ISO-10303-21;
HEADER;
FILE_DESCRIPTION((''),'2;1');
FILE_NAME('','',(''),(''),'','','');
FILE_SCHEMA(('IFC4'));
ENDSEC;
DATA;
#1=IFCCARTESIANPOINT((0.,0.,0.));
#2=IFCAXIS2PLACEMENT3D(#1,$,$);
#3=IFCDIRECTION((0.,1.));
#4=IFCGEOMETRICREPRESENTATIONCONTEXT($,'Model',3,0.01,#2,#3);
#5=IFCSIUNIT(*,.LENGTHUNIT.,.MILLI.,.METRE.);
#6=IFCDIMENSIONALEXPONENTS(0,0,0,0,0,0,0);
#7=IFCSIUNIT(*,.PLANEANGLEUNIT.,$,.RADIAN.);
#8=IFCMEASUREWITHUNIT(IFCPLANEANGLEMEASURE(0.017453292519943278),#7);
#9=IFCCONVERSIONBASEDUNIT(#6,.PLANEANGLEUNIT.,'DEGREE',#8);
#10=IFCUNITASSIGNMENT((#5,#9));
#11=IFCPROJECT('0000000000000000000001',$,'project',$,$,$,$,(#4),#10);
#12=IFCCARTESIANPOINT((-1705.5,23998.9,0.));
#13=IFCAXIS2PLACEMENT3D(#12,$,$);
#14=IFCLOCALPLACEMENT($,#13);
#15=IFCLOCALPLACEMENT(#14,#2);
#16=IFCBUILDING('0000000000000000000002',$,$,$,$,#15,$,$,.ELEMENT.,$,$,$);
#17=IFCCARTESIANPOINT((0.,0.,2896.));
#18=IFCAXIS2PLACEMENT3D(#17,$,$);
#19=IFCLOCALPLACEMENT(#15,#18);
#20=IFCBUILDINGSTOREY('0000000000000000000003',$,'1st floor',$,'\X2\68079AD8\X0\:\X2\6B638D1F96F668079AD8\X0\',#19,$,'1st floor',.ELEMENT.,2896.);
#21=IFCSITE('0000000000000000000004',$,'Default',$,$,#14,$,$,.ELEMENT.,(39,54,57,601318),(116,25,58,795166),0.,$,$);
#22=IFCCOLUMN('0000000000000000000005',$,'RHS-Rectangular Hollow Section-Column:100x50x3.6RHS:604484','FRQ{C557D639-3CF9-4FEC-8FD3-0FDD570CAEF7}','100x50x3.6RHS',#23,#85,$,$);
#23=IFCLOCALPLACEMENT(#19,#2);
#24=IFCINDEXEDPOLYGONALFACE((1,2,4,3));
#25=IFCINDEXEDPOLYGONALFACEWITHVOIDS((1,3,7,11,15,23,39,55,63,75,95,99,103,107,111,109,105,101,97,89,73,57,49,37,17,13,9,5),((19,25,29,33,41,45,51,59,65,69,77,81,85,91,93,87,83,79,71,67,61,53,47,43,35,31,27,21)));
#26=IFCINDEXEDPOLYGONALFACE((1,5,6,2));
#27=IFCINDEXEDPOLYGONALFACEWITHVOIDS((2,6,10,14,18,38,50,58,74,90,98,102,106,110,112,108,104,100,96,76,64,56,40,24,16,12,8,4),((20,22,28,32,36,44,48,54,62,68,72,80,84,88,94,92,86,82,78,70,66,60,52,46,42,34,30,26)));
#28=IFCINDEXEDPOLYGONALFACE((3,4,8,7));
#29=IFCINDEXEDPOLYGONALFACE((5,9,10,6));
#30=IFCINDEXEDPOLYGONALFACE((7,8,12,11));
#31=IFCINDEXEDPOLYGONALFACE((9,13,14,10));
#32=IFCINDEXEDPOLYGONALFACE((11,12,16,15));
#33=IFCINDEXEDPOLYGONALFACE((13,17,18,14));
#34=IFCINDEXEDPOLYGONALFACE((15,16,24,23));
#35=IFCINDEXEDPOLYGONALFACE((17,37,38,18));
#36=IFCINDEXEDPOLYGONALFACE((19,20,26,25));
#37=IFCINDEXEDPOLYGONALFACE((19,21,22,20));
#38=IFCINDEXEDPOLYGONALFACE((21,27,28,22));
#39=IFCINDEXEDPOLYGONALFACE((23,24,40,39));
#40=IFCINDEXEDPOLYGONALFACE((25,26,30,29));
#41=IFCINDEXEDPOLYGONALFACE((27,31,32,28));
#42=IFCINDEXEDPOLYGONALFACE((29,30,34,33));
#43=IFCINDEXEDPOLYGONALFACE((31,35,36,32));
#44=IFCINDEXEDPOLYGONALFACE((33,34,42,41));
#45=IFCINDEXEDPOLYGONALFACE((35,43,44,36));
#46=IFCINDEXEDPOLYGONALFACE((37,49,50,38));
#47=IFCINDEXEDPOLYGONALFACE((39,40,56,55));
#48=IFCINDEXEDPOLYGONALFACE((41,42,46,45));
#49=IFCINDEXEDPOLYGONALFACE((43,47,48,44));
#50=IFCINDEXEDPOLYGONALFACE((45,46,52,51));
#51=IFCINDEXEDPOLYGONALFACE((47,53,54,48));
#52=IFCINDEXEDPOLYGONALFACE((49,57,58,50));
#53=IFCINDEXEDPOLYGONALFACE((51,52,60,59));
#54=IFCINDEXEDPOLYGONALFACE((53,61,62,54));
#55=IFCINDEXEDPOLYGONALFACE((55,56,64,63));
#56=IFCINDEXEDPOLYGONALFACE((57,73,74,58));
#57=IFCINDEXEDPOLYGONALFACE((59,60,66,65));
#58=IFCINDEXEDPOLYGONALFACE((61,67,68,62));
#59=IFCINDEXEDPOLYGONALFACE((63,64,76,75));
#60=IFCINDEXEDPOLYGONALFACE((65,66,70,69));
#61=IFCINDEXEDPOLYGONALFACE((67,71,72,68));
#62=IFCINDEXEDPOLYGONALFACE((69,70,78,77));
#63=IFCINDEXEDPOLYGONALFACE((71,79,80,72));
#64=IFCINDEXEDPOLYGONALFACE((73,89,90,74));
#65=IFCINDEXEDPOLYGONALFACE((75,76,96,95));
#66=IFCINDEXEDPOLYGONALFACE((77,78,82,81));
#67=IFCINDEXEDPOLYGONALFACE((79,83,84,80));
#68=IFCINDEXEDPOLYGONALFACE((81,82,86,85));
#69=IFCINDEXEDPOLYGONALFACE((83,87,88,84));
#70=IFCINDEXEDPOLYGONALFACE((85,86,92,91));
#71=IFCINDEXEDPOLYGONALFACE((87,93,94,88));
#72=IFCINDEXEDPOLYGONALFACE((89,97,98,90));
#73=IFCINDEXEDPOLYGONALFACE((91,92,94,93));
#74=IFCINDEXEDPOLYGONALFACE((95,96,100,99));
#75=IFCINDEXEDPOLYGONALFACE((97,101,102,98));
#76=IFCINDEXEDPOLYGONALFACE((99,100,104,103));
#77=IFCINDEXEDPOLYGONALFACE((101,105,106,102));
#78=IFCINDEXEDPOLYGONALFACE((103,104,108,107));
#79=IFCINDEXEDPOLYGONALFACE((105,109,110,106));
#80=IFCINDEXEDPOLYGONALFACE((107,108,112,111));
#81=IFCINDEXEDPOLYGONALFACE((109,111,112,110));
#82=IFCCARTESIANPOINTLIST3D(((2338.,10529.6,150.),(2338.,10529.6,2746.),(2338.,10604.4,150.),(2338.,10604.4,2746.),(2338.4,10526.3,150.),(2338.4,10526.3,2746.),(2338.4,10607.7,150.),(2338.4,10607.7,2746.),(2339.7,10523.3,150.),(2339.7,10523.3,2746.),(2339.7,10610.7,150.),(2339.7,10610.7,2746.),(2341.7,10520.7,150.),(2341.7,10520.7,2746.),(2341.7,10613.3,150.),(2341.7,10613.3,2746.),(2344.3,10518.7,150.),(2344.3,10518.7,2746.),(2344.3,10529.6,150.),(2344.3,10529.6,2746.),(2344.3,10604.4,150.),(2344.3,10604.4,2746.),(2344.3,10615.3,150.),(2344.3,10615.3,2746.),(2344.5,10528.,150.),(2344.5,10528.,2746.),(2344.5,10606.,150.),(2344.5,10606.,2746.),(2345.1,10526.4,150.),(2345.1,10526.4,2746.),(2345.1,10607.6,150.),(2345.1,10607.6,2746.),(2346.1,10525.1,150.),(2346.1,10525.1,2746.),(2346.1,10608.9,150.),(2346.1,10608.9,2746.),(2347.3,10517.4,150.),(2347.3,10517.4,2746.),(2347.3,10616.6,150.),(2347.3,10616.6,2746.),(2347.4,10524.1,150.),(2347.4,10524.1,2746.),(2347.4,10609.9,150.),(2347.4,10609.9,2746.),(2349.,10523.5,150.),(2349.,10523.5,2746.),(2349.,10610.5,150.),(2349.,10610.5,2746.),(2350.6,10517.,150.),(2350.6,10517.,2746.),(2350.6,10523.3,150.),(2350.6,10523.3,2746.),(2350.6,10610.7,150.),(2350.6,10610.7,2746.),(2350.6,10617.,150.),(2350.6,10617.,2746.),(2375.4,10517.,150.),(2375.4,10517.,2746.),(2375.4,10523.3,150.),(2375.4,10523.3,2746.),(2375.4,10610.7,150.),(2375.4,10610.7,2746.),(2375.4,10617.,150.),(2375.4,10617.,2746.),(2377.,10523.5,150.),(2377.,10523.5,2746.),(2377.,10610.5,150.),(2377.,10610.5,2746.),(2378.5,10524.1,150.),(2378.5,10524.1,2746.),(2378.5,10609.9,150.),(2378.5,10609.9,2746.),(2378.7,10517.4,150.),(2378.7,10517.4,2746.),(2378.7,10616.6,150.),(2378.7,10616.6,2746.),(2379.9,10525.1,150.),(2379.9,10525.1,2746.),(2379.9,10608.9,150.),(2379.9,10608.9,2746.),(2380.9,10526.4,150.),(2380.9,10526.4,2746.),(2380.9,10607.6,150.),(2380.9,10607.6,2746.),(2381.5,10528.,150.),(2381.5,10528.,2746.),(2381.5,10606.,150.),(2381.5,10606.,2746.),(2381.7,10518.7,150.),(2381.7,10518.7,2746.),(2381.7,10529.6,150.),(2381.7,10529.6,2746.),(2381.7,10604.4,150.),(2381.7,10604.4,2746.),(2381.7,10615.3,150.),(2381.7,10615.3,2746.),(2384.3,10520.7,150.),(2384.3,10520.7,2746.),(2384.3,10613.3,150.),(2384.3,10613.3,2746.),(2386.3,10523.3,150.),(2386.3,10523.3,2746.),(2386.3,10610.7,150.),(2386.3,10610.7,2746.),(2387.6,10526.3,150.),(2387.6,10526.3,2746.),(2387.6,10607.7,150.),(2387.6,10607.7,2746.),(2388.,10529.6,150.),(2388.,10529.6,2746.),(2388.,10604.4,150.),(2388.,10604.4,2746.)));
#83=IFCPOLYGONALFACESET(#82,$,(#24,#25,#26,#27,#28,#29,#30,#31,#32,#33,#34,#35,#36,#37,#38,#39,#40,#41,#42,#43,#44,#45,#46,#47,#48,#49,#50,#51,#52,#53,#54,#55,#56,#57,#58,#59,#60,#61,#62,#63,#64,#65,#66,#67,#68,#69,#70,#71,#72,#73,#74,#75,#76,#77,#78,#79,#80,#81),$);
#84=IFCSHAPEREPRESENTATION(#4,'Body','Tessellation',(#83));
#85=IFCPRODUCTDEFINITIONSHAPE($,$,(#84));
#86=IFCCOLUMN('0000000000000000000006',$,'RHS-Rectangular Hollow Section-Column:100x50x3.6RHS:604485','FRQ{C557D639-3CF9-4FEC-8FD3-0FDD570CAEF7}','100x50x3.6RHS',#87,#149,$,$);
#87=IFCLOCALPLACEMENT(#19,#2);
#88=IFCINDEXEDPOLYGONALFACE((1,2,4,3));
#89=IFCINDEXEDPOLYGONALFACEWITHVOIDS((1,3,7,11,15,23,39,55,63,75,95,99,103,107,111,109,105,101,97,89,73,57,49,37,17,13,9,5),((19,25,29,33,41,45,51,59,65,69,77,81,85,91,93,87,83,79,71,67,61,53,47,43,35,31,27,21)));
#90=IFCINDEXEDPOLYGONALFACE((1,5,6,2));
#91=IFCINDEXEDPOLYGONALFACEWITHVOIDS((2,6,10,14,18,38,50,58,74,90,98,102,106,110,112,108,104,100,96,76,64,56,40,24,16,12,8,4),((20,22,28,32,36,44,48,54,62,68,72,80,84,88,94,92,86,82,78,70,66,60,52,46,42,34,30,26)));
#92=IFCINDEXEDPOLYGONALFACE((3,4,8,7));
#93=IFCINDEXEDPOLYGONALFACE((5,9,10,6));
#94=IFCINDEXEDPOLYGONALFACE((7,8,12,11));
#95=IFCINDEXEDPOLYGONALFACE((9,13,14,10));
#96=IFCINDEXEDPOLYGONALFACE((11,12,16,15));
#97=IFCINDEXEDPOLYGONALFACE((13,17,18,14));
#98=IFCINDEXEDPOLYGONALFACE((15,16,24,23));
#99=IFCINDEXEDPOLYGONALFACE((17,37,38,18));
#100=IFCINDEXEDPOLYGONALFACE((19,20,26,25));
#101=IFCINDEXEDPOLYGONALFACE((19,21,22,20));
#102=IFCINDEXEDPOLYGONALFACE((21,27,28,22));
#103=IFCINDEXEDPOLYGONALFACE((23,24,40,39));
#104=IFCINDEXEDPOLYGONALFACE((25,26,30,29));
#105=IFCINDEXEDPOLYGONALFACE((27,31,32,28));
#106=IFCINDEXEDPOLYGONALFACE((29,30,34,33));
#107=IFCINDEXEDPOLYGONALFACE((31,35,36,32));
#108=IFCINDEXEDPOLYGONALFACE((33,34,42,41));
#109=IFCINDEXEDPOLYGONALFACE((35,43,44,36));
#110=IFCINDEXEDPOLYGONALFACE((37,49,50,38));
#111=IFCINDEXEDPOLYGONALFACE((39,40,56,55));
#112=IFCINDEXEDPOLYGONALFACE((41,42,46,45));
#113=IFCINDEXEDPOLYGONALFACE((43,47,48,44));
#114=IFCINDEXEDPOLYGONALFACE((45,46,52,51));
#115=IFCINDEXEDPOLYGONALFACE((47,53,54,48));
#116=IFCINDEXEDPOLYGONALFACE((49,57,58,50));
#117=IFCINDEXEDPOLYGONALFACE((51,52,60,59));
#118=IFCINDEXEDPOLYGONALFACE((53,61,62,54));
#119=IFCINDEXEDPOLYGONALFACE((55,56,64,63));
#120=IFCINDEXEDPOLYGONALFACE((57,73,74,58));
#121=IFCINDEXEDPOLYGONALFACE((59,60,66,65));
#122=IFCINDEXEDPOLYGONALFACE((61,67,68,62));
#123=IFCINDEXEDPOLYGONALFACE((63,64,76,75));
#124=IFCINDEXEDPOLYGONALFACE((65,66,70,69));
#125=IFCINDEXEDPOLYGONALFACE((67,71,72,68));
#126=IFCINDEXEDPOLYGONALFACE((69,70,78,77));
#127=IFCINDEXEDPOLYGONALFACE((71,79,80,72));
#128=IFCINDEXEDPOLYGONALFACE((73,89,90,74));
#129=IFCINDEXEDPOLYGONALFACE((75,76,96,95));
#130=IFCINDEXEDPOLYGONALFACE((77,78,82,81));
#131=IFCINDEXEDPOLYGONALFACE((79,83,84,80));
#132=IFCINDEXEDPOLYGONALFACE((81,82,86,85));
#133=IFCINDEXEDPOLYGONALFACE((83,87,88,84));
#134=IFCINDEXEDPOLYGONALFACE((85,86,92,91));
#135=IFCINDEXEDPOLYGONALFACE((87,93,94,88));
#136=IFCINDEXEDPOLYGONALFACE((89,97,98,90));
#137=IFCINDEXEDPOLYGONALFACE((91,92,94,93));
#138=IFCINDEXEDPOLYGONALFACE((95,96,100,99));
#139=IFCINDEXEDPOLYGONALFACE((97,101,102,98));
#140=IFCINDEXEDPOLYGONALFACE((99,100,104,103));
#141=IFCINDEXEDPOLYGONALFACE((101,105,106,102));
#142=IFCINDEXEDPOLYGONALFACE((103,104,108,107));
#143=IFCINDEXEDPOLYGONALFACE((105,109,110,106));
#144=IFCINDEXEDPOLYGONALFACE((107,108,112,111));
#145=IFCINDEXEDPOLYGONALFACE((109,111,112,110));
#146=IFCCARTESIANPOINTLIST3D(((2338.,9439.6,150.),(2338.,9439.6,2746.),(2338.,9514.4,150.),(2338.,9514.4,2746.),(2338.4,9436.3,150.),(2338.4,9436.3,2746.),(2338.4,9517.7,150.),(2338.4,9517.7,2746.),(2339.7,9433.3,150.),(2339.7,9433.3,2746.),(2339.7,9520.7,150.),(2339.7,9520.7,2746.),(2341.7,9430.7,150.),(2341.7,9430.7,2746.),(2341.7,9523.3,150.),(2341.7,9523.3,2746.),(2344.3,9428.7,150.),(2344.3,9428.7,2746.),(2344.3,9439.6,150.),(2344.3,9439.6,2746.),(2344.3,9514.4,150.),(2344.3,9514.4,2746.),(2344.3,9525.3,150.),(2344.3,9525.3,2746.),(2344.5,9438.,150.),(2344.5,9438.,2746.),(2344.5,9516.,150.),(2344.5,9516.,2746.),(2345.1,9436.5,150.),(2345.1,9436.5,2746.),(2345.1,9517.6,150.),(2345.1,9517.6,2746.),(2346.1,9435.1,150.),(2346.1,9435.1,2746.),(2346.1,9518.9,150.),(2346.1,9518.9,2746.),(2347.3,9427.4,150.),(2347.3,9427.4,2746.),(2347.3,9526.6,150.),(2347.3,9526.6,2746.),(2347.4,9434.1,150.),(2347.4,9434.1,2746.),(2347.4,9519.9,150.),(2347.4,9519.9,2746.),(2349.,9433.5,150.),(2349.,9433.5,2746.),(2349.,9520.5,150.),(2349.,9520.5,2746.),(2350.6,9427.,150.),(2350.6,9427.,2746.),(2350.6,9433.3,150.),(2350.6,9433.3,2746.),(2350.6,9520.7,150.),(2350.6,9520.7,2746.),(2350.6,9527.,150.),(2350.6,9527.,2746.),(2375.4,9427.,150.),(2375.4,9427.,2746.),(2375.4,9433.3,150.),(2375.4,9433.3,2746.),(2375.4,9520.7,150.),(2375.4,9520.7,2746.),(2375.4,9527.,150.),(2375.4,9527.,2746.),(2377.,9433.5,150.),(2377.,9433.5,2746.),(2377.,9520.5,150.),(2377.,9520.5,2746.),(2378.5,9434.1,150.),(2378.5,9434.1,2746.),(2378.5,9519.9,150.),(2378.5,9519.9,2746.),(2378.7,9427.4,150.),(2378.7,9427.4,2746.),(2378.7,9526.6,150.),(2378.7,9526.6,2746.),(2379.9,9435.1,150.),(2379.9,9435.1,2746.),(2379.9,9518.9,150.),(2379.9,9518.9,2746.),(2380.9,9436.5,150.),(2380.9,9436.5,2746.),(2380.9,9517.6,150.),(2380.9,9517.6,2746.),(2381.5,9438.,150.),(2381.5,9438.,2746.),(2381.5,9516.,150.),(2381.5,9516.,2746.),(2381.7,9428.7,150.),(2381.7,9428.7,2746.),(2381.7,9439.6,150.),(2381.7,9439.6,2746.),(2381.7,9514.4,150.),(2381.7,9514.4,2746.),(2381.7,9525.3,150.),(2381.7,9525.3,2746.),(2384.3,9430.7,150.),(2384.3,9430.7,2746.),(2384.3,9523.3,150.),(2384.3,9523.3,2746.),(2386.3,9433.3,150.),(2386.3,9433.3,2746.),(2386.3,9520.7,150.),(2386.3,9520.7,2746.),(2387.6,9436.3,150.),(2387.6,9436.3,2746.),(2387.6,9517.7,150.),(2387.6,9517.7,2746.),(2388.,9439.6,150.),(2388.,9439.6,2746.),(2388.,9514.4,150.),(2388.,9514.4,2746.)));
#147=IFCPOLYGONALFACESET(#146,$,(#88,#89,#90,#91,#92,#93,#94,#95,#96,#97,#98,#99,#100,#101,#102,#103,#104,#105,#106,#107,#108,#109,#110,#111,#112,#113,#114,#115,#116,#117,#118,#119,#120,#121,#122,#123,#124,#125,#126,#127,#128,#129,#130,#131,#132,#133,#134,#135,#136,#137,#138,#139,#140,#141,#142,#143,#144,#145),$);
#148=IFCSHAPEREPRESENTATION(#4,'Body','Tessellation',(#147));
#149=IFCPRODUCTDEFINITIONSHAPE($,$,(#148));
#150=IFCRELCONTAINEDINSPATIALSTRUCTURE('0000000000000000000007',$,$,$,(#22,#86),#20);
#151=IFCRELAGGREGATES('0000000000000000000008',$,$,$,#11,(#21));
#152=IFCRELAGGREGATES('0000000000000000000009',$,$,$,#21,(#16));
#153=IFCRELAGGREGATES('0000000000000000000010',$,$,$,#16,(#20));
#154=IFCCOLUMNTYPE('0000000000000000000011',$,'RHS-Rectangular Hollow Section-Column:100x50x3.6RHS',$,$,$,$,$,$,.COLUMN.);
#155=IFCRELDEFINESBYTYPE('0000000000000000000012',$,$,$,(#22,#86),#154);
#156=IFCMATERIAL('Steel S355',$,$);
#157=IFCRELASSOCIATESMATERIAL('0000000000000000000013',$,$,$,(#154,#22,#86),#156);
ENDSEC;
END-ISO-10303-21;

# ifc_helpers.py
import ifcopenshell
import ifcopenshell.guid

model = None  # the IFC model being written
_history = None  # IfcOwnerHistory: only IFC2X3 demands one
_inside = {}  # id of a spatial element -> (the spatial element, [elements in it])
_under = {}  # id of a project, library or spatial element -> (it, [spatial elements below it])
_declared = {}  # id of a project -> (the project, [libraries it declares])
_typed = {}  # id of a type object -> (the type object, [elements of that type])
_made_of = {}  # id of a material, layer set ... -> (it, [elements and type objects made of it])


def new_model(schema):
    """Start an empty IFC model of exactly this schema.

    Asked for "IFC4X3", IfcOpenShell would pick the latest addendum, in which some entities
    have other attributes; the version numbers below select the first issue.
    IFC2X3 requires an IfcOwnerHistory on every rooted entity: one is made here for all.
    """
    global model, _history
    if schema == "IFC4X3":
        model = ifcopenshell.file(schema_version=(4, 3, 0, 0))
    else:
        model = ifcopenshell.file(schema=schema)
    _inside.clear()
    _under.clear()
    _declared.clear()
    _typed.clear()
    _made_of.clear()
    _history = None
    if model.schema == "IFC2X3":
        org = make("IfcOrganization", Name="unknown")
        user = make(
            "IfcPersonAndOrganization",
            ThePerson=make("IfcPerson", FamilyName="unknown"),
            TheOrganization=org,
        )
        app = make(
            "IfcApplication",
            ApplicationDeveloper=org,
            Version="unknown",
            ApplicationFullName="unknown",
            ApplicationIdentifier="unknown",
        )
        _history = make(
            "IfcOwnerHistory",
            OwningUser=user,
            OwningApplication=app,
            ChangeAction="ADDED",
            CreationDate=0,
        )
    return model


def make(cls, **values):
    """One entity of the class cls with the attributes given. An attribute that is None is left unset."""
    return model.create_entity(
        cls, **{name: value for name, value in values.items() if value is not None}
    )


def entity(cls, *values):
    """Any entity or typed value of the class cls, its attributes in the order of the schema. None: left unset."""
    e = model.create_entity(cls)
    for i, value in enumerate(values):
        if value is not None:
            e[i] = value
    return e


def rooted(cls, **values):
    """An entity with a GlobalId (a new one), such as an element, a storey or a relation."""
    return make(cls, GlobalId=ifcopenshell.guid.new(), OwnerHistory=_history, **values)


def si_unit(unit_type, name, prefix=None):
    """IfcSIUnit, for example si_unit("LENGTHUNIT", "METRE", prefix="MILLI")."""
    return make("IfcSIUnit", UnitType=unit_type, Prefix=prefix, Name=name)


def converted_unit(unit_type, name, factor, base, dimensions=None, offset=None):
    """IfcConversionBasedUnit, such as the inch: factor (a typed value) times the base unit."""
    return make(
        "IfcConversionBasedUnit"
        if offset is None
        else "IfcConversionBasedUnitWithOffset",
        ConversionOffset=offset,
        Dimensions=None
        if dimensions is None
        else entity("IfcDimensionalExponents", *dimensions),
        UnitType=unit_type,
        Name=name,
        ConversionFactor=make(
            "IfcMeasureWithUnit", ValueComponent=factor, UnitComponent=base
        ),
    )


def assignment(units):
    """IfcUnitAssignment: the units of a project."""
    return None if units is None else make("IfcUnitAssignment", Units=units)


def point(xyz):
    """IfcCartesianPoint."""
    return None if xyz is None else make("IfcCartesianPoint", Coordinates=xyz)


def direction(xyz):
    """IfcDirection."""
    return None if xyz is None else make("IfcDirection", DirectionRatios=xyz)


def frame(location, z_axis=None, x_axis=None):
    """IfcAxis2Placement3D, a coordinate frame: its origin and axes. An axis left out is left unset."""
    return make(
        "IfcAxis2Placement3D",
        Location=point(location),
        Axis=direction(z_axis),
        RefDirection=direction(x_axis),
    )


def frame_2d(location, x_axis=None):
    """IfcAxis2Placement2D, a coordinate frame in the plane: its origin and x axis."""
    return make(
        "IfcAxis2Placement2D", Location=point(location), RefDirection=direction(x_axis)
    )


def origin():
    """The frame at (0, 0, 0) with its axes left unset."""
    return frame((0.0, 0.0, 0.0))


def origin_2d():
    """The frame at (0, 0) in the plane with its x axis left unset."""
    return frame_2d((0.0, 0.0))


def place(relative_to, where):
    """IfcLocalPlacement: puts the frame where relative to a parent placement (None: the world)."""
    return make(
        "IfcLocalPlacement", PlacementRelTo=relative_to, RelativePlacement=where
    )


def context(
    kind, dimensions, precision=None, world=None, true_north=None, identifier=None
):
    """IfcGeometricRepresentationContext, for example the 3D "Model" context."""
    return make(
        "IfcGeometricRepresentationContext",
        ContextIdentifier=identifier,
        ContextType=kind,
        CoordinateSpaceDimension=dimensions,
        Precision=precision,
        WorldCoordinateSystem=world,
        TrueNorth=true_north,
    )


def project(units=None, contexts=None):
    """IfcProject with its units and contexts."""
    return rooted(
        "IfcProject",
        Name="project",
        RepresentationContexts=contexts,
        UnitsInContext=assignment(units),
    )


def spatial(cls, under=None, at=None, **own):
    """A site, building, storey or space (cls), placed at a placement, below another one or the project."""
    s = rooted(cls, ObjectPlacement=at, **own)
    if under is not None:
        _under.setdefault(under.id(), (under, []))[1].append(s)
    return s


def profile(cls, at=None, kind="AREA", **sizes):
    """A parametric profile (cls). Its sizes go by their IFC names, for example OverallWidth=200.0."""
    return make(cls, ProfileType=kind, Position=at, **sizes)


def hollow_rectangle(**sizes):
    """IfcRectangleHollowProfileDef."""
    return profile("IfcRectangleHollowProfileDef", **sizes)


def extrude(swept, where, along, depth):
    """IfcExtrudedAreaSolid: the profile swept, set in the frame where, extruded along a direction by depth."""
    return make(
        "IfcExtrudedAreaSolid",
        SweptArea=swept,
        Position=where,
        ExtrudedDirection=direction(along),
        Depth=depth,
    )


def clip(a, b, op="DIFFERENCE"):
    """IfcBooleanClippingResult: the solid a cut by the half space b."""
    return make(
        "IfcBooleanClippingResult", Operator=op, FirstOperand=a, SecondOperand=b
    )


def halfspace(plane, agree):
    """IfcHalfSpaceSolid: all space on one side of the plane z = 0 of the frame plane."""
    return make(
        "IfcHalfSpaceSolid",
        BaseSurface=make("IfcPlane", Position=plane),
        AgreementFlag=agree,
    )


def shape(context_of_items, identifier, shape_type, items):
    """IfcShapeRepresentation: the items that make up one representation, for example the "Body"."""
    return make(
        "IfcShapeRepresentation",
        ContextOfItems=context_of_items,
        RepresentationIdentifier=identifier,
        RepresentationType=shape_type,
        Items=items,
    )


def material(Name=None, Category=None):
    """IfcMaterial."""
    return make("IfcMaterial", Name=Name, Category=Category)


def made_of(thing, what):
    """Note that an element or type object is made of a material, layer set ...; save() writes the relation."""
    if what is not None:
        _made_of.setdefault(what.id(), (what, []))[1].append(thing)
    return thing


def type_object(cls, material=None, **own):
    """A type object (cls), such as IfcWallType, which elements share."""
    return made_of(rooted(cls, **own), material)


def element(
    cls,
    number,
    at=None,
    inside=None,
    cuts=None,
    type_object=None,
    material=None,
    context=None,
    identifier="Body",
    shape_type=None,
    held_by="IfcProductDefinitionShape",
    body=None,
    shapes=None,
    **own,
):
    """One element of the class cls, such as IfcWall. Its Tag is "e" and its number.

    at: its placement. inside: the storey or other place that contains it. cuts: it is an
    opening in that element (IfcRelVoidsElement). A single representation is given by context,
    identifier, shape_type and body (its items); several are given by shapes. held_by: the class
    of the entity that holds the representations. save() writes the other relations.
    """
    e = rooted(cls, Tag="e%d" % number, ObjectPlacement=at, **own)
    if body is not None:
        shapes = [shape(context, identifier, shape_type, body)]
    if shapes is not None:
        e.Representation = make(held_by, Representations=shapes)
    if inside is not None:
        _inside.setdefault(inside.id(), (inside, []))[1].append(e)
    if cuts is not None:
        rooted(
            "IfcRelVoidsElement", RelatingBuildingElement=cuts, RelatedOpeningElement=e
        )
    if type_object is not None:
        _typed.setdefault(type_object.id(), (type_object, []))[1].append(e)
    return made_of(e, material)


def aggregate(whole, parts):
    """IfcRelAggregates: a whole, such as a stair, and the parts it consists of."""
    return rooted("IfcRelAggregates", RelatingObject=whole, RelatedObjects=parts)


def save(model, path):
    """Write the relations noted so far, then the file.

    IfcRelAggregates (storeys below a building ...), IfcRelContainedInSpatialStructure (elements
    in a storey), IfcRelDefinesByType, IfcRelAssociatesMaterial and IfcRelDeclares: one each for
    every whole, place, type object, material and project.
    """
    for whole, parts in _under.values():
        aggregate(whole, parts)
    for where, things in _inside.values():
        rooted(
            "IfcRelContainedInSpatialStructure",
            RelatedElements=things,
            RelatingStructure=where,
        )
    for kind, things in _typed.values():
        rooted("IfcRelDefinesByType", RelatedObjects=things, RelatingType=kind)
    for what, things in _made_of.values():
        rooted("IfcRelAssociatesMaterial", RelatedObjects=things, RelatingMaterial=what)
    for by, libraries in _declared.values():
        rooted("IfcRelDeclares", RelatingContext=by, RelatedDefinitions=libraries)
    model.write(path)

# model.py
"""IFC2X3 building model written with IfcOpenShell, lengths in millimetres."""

from ifc_helpers import new_model, entity, si_unit, converted_unit, direction, frame, origin, origin_2d, place, context, project, spatial, hollow_rectangle, extrude, clip, halfspace, material, type_object, element, save


model = new_model("IFC2X3")

# Units and contexts
model_context = context("Model", 3, precision=0.01, world=origin(), true_north=direction((0.0, 1.0)))
ifc_project = project(units=[si_unit("LENGTHUNIT", "METRE", prefix="MILLI"), converted_unit("PLANEANGLEUNIT", "DEGREE", entity("IfcPlaneAngleMeasure", 0.017453292519943278), si_unit("PLANEANGLEUNIT", "RADIAN"), dimensions=[0, 0, 0, 0, 0, 0, 0])], contexts=[model_context])

# Site, building, storey
site_placement = place(None, frame((-1705.5, 23998.9, 0.0)))
site = spatial("IfcSite", under=ifc_project, at=site_placement, Name="Default", CompositionType="ELEMENT", RefLatitude=(39, 54, 57, 601318), RefLongitude=(116, 25, 58, 795166), RefElevation=0.0)
building_placement = place(site_placement, origin())
building = spatial("IfcBuilding", under=site, at=building_placement, CompositionType="ELEMENT")
storey_placement = place(building_placement, frame((0.0, 0.0, 2896.0)))
storey = spatial("IfcBuildingStorey", under=building, at=storey_placement, Name="1st floor", ObjectType="标高:正负零标高", LongName="1st floor", CompositionType="ELEMENT", Elevation=2896.0)

# Columns
ifc_material_1 = material(Name="Steel S355")
column_type_1 = type_object("IfcColumnType", Name="RHS-Rectangular Hollow Section-Column:100x50x3.6RHS", PredefinedType="COLUMN", material=ifc_material_1)
column_1_placement = place(storey_placement, frame((2363.0, 10567.0, 2746.0), z_axis=(0.0, 0.0, 1.0), x_axis=(-1.0, 0.0, 0.0)))
element("IfcColumn", 1, at=column_1_placement, inside=storey, type_object=column_type_1, material=ifc_material_1, Name="RHS-Rectangular Hollow Section-Column:100x50x3.6RHS:604484", Description="FRQ{C557D639-3CF9-4FEC-8FD3-0FDD570CAEF7}", ObjectType="100x50x3.6RHS", context=model_context, shape_type="Clipping", body=[
    clip(extrude(hollow_rectangle(XDim=50.0, YDim=100.0, WallThickness=6.3, InnerFilletRadius=6.3, OuterFilletRadius=12.6, at=origin_2d()), origin(), (0.0, 0.0, -1.0), 2651.9), halfspace(frame((2363.0, 10567.0, -2596.0), z_axis=(0.0, 0.0, 1.0), x_axis=(-1.0, 0.0, 0.0)), True)),
])
column_2_placement = place(storey_placement, frame((2363.0, 9477.0, 2746.0), z_axis=(0.0, 0.0, 1.0), x_axis=(-1.0, 0.0, 0.0)))
element("IfcColumn", 2, at=column_2_placement, inside=storey, type_object=column_type_1, material=ifc_material_1, Name="RHS-Rectangular Hollow Section-Column:100x50x3.6RHS:604485", Description="FRQ{C557D639-3CF9-4FEC-8FD3-0FDD570CAEF7}", ObjectType="100x50x3.6RHS", context=model_context, shape_type="Clipping", body=[
    clip(extrude(hollow_rectangle(XDim=50.0, YDim=100.0, WallThickness=6.3, InnerFilletRadius=6.3, OuterFilletRadius=12.6, at=origin_2d()), origin(), (0.0, 0.0, -1.0), 2651.9), halfspace(frame((2363.0, 9477.0, -2596.0), z_axis=(0.0, 0.0, 1.0), x_axis=(-1.0, 0.0, 0.0)), True)),
])

save(model, "model.ifc")
